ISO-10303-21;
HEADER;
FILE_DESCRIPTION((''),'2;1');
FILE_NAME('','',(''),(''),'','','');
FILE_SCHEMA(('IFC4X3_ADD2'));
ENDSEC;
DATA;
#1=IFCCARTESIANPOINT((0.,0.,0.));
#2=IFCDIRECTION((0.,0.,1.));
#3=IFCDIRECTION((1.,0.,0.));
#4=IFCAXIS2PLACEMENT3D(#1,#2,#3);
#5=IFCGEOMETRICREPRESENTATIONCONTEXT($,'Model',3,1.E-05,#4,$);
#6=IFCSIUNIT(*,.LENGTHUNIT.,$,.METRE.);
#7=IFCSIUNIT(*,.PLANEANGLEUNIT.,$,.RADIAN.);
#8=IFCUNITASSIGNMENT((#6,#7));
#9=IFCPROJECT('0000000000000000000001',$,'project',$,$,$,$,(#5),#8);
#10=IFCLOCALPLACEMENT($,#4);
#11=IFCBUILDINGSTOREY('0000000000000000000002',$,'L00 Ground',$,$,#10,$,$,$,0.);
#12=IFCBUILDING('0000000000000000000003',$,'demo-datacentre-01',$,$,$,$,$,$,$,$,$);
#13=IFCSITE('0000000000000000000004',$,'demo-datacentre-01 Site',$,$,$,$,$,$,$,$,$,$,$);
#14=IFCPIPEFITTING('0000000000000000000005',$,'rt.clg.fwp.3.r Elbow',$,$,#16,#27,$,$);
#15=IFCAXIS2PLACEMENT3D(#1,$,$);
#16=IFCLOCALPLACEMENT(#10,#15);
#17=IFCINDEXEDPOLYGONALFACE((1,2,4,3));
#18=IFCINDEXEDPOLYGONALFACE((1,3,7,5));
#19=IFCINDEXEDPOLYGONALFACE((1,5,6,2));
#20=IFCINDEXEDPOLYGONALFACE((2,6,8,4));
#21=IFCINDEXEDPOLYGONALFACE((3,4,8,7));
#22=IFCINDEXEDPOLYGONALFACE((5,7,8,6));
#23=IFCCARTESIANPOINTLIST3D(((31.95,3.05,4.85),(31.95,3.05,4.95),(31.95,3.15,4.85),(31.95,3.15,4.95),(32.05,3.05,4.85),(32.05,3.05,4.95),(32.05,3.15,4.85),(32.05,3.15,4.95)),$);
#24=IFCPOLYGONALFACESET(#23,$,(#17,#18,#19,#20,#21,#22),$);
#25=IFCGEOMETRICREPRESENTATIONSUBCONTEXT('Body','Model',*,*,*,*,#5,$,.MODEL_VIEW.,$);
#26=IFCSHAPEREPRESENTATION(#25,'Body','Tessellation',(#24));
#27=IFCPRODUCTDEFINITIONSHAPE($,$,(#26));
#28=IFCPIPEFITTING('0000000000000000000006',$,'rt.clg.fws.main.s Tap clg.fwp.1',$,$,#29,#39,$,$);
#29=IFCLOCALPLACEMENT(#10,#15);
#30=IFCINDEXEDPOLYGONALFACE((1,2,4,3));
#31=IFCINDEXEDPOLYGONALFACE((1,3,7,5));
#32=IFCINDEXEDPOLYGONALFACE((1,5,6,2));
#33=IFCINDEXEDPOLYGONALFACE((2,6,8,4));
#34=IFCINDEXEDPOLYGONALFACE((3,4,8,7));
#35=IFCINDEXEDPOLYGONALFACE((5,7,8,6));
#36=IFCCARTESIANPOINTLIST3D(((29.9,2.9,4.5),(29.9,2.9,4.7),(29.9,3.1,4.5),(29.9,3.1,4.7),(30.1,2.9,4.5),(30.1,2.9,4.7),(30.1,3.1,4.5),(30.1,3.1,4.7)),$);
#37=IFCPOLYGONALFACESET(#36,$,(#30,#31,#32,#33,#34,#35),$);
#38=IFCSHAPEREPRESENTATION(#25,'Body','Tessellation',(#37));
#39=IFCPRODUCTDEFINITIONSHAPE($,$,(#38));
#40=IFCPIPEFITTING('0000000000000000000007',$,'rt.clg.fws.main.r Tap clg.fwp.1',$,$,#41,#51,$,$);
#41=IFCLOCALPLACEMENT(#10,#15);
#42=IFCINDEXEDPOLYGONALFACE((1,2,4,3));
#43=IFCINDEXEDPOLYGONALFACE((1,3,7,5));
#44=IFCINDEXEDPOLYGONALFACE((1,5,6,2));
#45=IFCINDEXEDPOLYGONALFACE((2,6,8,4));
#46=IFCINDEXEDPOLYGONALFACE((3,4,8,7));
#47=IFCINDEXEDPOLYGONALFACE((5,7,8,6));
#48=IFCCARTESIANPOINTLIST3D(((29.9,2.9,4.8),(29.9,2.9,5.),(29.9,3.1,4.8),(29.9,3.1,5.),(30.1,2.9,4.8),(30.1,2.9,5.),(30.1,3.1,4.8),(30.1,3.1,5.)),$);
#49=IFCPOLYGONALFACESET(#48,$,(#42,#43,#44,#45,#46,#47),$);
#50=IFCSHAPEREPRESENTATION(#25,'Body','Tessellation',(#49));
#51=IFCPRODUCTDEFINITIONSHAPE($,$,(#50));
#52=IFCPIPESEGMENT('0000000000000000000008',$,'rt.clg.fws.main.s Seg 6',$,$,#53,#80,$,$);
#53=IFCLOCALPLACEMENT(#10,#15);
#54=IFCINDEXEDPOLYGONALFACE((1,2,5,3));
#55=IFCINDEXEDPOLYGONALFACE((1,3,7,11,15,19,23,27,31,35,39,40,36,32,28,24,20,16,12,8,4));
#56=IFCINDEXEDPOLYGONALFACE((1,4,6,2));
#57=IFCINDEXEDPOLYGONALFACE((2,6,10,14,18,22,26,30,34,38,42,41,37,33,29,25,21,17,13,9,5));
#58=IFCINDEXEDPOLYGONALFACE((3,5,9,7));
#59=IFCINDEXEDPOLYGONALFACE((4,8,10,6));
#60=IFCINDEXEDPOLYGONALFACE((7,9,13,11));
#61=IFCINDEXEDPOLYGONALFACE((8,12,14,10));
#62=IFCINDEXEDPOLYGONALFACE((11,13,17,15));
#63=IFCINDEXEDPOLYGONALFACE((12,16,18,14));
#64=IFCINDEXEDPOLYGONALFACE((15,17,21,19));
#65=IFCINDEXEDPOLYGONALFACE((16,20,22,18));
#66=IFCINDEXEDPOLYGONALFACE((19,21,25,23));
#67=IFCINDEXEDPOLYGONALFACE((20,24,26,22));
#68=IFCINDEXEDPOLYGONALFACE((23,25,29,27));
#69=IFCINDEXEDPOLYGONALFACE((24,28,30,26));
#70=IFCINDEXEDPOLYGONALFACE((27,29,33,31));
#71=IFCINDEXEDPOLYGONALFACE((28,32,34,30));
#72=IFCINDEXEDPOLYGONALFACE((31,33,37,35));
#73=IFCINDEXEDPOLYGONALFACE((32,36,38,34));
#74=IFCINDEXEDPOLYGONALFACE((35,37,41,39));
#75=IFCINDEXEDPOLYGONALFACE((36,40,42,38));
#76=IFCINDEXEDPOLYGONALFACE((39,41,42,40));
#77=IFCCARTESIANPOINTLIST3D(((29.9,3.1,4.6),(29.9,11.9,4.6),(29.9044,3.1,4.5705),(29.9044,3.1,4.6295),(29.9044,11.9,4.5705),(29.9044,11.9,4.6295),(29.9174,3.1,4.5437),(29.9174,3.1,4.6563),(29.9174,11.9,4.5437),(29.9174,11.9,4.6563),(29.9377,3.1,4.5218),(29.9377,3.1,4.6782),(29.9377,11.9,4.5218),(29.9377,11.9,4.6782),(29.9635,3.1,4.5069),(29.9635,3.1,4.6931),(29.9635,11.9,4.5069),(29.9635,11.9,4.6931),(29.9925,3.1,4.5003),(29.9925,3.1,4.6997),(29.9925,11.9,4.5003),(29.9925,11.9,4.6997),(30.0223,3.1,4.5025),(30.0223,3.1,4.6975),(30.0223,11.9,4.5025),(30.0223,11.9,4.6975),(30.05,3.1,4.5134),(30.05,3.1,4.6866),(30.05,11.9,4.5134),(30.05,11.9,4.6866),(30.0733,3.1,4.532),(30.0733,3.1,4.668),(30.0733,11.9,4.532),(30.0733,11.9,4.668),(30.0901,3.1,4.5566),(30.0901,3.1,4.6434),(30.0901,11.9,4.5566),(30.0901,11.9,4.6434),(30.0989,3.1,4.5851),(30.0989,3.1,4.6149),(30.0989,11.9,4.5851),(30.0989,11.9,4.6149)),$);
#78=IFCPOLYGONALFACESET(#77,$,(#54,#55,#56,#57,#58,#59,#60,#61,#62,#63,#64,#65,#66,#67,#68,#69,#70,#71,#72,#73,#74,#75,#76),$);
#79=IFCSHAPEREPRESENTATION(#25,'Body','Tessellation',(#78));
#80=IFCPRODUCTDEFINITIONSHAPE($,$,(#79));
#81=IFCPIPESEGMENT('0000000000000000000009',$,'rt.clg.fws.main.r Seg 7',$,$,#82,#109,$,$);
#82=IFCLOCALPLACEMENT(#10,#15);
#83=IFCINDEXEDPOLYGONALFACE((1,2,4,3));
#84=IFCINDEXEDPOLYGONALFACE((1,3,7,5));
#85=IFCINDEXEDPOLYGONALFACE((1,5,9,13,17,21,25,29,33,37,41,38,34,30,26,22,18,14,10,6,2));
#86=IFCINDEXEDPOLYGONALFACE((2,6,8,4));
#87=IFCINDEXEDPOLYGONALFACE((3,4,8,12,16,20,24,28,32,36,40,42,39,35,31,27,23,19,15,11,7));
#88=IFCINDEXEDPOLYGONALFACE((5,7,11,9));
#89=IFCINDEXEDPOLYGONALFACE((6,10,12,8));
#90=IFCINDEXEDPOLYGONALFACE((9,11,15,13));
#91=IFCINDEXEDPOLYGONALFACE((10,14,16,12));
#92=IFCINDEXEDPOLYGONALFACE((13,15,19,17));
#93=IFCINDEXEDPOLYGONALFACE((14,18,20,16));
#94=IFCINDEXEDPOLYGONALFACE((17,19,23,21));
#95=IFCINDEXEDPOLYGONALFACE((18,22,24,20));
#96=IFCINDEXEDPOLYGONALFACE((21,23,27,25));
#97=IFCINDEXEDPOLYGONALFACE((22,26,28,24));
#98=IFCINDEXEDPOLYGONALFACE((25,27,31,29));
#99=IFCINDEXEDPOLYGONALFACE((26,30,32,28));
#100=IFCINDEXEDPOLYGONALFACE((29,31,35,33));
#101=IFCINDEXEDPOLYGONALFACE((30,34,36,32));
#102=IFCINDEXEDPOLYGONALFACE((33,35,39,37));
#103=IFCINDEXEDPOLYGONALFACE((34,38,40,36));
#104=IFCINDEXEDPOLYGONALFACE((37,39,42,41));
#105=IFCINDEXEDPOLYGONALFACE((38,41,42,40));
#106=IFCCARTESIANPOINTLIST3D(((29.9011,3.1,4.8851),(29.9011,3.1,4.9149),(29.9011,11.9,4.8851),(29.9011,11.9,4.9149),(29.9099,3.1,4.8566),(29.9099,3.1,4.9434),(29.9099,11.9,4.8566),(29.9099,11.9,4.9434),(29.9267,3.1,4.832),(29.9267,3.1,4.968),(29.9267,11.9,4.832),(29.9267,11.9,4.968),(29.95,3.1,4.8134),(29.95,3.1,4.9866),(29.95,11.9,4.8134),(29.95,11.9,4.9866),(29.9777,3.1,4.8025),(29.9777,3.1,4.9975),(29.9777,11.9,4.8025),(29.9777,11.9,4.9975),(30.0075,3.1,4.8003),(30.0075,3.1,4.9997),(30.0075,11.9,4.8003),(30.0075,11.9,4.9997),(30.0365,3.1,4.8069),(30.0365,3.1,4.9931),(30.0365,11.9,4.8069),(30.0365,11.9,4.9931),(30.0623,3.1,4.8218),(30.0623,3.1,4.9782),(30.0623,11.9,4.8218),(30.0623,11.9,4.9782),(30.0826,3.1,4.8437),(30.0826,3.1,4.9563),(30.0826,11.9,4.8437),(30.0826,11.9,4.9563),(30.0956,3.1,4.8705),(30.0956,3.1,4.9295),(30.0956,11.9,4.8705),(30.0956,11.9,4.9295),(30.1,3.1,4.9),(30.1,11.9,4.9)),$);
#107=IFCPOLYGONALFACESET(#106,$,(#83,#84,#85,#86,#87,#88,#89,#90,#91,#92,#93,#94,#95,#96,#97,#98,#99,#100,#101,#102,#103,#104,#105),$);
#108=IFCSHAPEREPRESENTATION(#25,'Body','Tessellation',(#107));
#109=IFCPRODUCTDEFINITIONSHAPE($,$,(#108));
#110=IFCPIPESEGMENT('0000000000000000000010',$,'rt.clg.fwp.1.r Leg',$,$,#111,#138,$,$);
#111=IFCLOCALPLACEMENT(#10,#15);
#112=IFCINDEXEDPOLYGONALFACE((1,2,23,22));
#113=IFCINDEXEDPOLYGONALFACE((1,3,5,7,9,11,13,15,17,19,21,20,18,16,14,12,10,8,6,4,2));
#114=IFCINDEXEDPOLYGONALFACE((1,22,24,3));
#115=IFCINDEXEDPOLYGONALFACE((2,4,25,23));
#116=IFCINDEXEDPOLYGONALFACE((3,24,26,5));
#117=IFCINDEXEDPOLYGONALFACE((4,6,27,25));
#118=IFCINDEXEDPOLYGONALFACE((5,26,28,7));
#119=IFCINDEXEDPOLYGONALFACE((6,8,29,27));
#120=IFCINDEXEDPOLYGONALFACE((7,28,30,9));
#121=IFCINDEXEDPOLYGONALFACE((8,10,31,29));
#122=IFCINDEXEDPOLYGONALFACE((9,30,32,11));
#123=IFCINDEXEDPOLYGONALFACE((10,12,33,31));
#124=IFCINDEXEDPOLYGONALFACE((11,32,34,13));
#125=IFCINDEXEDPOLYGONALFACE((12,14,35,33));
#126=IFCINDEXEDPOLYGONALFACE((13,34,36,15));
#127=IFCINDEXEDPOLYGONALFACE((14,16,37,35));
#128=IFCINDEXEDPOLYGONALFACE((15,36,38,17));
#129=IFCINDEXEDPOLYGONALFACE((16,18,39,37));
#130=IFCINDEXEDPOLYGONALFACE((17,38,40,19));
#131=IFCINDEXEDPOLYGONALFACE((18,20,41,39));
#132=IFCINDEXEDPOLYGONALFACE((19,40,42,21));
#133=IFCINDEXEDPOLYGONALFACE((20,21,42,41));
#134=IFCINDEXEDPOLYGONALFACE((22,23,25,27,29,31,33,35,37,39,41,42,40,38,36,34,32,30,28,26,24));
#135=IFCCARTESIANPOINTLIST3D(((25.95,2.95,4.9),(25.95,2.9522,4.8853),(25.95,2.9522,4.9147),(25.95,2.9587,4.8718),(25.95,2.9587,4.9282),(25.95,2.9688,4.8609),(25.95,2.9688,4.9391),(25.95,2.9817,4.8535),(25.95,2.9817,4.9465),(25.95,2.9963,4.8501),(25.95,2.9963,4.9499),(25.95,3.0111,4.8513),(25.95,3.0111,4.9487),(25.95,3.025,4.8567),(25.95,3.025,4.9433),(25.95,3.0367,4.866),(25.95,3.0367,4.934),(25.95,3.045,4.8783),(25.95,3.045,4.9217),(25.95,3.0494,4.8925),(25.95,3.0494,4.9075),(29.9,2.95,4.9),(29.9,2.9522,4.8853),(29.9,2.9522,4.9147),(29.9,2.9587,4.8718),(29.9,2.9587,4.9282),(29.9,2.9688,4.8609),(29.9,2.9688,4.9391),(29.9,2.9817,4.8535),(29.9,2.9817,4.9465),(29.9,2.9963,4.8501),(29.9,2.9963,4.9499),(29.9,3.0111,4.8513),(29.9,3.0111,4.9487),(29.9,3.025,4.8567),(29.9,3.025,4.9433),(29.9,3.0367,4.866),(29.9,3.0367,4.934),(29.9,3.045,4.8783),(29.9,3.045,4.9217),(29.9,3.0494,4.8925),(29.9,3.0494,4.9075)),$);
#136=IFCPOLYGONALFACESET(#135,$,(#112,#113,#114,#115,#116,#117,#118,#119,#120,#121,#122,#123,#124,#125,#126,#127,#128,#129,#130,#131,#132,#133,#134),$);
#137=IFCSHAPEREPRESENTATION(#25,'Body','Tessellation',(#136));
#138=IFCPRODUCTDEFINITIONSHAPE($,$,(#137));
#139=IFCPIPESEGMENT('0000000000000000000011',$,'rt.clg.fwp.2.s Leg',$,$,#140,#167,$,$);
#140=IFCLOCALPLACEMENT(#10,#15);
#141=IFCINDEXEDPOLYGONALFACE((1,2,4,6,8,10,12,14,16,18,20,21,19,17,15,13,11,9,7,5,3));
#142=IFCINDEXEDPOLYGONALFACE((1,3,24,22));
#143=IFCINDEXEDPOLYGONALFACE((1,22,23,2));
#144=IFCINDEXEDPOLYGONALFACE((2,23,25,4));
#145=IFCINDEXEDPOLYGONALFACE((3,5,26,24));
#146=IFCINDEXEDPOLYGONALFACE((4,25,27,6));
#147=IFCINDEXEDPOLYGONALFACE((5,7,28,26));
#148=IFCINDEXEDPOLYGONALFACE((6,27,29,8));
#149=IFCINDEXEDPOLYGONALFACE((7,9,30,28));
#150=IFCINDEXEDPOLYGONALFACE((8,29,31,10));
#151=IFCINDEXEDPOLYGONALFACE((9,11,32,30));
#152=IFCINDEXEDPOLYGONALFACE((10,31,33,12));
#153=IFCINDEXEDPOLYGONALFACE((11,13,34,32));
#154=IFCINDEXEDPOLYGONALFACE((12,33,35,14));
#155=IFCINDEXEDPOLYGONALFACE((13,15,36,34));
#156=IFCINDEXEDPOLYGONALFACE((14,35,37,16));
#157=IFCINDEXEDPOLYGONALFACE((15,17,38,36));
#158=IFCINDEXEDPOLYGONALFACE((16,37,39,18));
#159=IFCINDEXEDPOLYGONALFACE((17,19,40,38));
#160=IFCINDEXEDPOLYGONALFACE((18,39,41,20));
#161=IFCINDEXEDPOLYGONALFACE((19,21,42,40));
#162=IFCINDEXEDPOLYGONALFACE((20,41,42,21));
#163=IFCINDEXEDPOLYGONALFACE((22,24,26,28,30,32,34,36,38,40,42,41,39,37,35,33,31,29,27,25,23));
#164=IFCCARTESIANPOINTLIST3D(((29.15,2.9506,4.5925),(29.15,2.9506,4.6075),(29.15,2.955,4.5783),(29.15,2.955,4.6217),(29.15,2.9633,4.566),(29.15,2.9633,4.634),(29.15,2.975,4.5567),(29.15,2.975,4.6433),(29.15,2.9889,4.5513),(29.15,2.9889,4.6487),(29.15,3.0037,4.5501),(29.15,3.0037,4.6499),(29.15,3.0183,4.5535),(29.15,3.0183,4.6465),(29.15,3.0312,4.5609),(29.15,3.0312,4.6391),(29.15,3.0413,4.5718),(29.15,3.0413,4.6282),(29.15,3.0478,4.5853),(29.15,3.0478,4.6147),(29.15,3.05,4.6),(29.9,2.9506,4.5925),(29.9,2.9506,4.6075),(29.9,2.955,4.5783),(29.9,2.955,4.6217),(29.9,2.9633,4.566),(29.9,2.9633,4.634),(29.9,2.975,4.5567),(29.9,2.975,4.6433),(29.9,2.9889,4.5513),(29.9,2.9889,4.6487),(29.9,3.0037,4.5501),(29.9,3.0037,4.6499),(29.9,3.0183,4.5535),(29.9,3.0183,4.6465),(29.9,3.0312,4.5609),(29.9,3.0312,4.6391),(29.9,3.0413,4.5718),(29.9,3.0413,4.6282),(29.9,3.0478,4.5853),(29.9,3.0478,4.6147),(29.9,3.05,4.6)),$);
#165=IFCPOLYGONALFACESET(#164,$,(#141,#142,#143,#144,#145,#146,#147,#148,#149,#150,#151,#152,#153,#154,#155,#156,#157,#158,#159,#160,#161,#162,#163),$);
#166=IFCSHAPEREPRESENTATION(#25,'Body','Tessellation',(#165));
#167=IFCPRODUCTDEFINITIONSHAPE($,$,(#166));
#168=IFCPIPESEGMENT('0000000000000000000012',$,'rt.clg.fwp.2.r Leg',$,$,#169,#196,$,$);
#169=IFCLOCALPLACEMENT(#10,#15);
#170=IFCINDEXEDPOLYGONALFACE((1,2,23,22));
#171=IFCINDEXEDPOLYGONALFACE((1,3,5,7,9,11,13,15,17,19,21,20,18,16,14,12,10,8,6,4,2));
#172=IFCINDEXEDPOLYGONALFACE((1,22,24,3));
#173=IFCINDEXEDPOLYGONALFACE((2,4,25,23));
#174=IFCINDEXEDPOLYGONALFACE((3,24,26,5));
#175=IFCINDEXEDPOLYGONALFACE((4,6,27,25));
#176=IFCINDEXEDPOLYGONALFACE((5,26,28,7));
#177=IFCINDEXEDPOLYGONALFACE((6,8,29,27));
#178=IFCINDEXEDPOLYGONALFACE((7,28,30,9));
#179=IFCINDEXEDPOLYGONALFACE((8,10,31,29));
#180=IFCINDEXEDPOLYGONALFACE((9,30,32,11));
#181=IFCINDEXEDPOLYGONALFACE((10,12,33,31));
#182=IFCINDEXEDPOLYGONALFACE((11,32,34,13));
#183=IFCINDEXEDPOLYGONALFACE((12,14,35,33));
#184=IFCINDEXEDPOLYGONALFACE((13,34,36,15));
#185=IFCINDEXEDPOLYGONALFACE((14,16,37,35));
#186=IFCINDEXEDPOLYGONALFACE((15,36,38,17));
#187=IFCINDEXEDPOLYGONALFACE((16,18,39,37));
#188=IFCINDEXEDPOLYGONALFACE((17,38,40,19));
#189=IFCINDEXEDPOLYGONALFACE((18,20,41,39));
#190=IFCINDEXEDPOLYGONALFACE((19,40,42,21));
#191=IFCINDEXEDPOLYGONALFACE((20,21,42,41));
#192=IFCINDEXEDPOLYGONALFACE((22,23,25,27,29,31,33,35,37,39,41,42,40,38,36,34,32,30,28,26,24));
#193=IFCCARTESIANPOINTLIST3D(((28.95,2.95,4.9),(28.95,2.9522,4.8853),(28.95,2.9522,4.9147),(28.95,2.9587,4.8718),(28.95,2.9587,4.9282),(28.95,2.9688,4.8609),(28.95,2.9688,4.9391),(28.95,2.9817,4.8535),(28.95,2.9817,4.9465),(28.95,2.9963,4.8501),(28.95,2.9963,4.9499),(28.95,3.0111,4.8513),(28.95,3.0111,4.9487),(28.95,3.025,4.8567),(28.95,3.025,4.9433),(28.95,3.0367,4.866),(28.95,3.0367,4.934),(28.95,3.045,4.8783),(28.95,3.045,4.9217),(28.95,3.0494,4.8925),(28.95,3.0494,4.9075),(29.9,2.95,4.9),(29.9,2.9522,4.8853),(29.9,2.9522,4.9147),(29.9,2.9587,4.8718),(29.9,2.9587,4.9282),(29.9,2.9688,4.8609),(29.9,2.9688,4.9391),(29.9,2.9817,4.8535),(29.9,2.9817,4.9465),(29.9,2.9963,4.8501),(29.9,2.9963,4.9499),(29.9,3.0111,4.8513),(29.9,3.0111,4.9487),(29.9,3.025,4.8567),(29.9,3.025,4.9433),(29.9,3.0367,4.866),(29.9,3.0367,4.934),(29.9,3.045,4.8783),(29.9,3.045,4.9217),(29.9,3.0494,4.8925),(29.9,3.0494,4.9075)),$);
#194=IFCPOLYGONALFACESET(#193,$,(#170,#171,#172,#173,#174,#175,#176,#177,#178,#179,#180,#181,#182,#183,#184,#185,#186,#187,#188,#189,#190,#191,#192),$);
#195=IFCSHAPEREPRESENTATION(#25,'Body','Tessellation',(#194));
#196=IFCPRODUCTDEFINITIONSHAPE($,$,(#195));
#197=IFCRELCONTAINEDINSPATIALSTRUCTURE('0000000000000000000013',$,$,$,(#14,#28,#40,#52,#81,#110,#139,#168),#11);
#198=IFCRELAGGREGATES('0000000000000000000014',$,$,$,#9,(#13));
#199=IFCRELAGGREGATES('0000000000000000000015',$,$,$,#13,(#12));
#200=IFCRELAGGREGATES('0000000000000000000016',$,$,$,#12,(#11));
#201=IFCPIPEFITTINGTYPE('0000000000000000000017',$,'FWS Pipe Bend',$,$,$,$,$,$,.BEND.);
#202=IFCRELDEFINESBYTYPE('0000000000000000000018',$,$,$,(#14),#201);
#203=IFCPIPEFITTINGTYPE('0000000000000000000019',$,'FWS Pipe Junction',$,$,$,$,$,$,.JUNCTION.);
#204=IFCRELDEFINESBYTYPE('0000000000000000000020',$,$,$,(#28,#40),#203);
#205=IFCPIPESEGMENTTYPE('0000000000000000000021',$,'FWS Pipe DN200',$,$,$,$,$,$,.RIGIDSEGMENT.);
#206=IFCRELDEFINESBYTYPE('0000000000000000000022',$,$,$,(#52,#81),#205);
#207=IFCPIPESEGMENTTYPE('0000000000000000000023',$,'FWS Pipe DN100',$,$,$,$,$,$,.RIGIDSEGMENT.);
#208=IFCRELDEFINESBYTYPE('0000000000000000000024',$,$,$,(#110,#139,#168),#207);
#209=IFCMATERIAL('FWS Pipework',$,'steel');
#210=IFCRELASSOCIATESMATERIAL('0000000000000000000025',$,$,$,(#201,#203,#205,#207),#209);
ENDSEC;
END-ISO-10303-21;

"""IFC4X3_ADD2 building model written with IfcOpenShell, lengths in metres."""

from ifc_helpers import new_model, si_unit, frame, origin_with_axes, place, context, subcontext, project, spatial, rectangle, circle, extrude, material, type_object, element, save


model = new_model("IFC4X3_ADD2")

# Units and contexts
model_context = context("Model", 3, precision=1e-05, world=origin_with_axes())
body_context = subcontext(model_context, "Body", "Model", "MODEL_VIEW")
ifc_project = project(units=[si_unit("LENGTHUNIT", "METRE"), si_unit("PLANEANGLEUNIT", "RADIAN")], contexts=[model_context])

# Site, building, storey
site = spatial("IfcSite", under=ifc_project, Name="demo-datacentre-01 Site")
building = spatial("IfcBuilding", under=site, Name="demo-datacentre-01")
storey_placement = place(None, origin_with_axes())
storey = spatial("IfcBuildingStorey", under=building, at=storey_placement, Name="L00 Ground", Elevation=0.0)

# Pipe fittings
ifc_material_1 = material(Name="FWS Pipework", Category="steel")
pipe_fitting_type_1 = type_object("IfcPipeFittingType", Name="FWS Pipe Bend", PredefinedType="BEND", material=ifc_material_1)
pipe_fitting_placement = place(storey_placement, frame((32.0, 3.1, 4.85), z_axis=(0.0, 0.0, 1.0), x_axis=(1.0, 0.0, 0.0)))
element("IfcPipeFitting", 1, at=pipe_fitting_placement, inside=storey, type_object=pipe_fitting_type_1, Name="rt.clg.fwp.3.r Elbow", context=body_context, shape_type="SweptSolid", body=[
    extrude(rectangle(XDim=0.1, YDim=0.1), origin_with_axes(), (0.0, 0.0, 1.0), 0.1),
])
pipe_fitting_type_2 = type_object("IfcPipeFittingType", Name="FWS Pipe Junction", PredefinedType="JUNCTION", material=ifc_material_1)
for number, where, z_axis, x_axis, name in (
    (2, (30.0, 3.0, 4.5), (0.0, 0.0, 1.0), (1.0, 0.0, 0.0), "rt.clg.fws.main.s Tap clg.fwp.1"),
    (3, (30.0, 3.0, 4.8), (0.0, 0.0, 1.0), (1.0, 0.0, 0.0), "rt.clg.fws.main.r Tap clg.fwp.1"),
):
    element("IfcPipeFitting", number, at=place(storey_placement, frame(where, z_axis=z_axis, x_axis=x_axis)), inside=storey, type_object=pipe_fitting_type_2, Name=name, context=body_context, shape_type="SweptSolid", body=[
        extrude(rectangle(XDim=0.2, YDim=0.2), origin_with_axes(), (0.0, 0.0, 1.0), 0.2),
    ])

# Pipe segments
pipe_segment_type_1 = type_object("IfcPipeSegmentType", Name="FWS Pipe DN200", PredefinedType="RIGIDSEGMENT", material=ifc_material_1)
for number, where, z_axis, x_axis, name in (
    (4, (30.0, 3.1, 4.6), (0.0, 1.0, 0.0), (-1.0, 0.0, 0.0), "rt.clg.fws.main.s Seg 6"),
    (5, (30.0, 11.9, 4.9), (0.0, -1.0, 0.0), (1.0, 0.0, 0.0), "rt.clg.fws.main.r Seg 7"),
):
    element("IfcPipeSegment", number, at=place(storey_placement, frame(where, z_axis=z_axis, x_axis=x_axis)), inside=storey, type_object=pipe_segment_type_1, Name=name, context=body_context, shape_type="SweptSolid", body=[
        extrude(circle(Radius=0.1), origin_with_axes(), (0.0, 0.0, 1.0), 8.8),
    ])
pipe_segment_type_2 = type_object("IfcPipeSegmentType", Name="FWS Pipe DN100", PredefinedType="RIGIDSEGMENT", material=ifc_material_1)
pipe_segment_1_placement = place(storey_placement, frame((29.9, 3.0, 4.9), z_axis=(-1.0, 0.0, 0.0), x_axis=(0.0, -1.0, 0.0)))
element("IfcPipeSegment", 6, at=pipe_segment_1_placement, inside=storey, type_object=pipe_segment_type_2, Name="rt.clg.fwp.1.r Leg", context=body_context, shape_type="SweptSolid", body=[
    extrude(circle(Radius=0.05), origin_with_axes(), (0.0, 0.0, 1.0), 3.95),
])
pipe_segment_2_placement = place(storey_placement, frame((29.15, 3.0, 4.6), z_axis=(1.0, 0.0, 0.0), x_axis=(0.0, 1.0, 0.0)))
element("IfcPipeSegment", 7, at=pipe_segment_2_placement, inside=storey, type_object=pipe_segment_type_2, Name="rt.clg.fwp.2.s Leg", context=body_context, shape_type="SweptSolid", body=[
    extrude(circle(Radius=0.05), origin_with_axes(), (0.0, 0.0, 1.0), 0.75),
])
pipe_segment_3_placement = place(storey_placement, frame((29.9, 3.0, 4.9), z_axis=(-1.0, 0.0, 0.0), x_axis=(0.0, -1.0, 0.0)))
element("IfcPipeSegment", 8, at=pipe_segment_3_placement, inside=storey, type_object=pipe_segment_type_2, Name="rt.clg.fwp.2.r Leg", context=body_context, shape_type="SweptSolid", body=[
    extrude(circle(Radius=0.05), origin_with_axes(), (0.0, 0.0, 1.0), 0.95),
])

save(model, "model.ifc")
